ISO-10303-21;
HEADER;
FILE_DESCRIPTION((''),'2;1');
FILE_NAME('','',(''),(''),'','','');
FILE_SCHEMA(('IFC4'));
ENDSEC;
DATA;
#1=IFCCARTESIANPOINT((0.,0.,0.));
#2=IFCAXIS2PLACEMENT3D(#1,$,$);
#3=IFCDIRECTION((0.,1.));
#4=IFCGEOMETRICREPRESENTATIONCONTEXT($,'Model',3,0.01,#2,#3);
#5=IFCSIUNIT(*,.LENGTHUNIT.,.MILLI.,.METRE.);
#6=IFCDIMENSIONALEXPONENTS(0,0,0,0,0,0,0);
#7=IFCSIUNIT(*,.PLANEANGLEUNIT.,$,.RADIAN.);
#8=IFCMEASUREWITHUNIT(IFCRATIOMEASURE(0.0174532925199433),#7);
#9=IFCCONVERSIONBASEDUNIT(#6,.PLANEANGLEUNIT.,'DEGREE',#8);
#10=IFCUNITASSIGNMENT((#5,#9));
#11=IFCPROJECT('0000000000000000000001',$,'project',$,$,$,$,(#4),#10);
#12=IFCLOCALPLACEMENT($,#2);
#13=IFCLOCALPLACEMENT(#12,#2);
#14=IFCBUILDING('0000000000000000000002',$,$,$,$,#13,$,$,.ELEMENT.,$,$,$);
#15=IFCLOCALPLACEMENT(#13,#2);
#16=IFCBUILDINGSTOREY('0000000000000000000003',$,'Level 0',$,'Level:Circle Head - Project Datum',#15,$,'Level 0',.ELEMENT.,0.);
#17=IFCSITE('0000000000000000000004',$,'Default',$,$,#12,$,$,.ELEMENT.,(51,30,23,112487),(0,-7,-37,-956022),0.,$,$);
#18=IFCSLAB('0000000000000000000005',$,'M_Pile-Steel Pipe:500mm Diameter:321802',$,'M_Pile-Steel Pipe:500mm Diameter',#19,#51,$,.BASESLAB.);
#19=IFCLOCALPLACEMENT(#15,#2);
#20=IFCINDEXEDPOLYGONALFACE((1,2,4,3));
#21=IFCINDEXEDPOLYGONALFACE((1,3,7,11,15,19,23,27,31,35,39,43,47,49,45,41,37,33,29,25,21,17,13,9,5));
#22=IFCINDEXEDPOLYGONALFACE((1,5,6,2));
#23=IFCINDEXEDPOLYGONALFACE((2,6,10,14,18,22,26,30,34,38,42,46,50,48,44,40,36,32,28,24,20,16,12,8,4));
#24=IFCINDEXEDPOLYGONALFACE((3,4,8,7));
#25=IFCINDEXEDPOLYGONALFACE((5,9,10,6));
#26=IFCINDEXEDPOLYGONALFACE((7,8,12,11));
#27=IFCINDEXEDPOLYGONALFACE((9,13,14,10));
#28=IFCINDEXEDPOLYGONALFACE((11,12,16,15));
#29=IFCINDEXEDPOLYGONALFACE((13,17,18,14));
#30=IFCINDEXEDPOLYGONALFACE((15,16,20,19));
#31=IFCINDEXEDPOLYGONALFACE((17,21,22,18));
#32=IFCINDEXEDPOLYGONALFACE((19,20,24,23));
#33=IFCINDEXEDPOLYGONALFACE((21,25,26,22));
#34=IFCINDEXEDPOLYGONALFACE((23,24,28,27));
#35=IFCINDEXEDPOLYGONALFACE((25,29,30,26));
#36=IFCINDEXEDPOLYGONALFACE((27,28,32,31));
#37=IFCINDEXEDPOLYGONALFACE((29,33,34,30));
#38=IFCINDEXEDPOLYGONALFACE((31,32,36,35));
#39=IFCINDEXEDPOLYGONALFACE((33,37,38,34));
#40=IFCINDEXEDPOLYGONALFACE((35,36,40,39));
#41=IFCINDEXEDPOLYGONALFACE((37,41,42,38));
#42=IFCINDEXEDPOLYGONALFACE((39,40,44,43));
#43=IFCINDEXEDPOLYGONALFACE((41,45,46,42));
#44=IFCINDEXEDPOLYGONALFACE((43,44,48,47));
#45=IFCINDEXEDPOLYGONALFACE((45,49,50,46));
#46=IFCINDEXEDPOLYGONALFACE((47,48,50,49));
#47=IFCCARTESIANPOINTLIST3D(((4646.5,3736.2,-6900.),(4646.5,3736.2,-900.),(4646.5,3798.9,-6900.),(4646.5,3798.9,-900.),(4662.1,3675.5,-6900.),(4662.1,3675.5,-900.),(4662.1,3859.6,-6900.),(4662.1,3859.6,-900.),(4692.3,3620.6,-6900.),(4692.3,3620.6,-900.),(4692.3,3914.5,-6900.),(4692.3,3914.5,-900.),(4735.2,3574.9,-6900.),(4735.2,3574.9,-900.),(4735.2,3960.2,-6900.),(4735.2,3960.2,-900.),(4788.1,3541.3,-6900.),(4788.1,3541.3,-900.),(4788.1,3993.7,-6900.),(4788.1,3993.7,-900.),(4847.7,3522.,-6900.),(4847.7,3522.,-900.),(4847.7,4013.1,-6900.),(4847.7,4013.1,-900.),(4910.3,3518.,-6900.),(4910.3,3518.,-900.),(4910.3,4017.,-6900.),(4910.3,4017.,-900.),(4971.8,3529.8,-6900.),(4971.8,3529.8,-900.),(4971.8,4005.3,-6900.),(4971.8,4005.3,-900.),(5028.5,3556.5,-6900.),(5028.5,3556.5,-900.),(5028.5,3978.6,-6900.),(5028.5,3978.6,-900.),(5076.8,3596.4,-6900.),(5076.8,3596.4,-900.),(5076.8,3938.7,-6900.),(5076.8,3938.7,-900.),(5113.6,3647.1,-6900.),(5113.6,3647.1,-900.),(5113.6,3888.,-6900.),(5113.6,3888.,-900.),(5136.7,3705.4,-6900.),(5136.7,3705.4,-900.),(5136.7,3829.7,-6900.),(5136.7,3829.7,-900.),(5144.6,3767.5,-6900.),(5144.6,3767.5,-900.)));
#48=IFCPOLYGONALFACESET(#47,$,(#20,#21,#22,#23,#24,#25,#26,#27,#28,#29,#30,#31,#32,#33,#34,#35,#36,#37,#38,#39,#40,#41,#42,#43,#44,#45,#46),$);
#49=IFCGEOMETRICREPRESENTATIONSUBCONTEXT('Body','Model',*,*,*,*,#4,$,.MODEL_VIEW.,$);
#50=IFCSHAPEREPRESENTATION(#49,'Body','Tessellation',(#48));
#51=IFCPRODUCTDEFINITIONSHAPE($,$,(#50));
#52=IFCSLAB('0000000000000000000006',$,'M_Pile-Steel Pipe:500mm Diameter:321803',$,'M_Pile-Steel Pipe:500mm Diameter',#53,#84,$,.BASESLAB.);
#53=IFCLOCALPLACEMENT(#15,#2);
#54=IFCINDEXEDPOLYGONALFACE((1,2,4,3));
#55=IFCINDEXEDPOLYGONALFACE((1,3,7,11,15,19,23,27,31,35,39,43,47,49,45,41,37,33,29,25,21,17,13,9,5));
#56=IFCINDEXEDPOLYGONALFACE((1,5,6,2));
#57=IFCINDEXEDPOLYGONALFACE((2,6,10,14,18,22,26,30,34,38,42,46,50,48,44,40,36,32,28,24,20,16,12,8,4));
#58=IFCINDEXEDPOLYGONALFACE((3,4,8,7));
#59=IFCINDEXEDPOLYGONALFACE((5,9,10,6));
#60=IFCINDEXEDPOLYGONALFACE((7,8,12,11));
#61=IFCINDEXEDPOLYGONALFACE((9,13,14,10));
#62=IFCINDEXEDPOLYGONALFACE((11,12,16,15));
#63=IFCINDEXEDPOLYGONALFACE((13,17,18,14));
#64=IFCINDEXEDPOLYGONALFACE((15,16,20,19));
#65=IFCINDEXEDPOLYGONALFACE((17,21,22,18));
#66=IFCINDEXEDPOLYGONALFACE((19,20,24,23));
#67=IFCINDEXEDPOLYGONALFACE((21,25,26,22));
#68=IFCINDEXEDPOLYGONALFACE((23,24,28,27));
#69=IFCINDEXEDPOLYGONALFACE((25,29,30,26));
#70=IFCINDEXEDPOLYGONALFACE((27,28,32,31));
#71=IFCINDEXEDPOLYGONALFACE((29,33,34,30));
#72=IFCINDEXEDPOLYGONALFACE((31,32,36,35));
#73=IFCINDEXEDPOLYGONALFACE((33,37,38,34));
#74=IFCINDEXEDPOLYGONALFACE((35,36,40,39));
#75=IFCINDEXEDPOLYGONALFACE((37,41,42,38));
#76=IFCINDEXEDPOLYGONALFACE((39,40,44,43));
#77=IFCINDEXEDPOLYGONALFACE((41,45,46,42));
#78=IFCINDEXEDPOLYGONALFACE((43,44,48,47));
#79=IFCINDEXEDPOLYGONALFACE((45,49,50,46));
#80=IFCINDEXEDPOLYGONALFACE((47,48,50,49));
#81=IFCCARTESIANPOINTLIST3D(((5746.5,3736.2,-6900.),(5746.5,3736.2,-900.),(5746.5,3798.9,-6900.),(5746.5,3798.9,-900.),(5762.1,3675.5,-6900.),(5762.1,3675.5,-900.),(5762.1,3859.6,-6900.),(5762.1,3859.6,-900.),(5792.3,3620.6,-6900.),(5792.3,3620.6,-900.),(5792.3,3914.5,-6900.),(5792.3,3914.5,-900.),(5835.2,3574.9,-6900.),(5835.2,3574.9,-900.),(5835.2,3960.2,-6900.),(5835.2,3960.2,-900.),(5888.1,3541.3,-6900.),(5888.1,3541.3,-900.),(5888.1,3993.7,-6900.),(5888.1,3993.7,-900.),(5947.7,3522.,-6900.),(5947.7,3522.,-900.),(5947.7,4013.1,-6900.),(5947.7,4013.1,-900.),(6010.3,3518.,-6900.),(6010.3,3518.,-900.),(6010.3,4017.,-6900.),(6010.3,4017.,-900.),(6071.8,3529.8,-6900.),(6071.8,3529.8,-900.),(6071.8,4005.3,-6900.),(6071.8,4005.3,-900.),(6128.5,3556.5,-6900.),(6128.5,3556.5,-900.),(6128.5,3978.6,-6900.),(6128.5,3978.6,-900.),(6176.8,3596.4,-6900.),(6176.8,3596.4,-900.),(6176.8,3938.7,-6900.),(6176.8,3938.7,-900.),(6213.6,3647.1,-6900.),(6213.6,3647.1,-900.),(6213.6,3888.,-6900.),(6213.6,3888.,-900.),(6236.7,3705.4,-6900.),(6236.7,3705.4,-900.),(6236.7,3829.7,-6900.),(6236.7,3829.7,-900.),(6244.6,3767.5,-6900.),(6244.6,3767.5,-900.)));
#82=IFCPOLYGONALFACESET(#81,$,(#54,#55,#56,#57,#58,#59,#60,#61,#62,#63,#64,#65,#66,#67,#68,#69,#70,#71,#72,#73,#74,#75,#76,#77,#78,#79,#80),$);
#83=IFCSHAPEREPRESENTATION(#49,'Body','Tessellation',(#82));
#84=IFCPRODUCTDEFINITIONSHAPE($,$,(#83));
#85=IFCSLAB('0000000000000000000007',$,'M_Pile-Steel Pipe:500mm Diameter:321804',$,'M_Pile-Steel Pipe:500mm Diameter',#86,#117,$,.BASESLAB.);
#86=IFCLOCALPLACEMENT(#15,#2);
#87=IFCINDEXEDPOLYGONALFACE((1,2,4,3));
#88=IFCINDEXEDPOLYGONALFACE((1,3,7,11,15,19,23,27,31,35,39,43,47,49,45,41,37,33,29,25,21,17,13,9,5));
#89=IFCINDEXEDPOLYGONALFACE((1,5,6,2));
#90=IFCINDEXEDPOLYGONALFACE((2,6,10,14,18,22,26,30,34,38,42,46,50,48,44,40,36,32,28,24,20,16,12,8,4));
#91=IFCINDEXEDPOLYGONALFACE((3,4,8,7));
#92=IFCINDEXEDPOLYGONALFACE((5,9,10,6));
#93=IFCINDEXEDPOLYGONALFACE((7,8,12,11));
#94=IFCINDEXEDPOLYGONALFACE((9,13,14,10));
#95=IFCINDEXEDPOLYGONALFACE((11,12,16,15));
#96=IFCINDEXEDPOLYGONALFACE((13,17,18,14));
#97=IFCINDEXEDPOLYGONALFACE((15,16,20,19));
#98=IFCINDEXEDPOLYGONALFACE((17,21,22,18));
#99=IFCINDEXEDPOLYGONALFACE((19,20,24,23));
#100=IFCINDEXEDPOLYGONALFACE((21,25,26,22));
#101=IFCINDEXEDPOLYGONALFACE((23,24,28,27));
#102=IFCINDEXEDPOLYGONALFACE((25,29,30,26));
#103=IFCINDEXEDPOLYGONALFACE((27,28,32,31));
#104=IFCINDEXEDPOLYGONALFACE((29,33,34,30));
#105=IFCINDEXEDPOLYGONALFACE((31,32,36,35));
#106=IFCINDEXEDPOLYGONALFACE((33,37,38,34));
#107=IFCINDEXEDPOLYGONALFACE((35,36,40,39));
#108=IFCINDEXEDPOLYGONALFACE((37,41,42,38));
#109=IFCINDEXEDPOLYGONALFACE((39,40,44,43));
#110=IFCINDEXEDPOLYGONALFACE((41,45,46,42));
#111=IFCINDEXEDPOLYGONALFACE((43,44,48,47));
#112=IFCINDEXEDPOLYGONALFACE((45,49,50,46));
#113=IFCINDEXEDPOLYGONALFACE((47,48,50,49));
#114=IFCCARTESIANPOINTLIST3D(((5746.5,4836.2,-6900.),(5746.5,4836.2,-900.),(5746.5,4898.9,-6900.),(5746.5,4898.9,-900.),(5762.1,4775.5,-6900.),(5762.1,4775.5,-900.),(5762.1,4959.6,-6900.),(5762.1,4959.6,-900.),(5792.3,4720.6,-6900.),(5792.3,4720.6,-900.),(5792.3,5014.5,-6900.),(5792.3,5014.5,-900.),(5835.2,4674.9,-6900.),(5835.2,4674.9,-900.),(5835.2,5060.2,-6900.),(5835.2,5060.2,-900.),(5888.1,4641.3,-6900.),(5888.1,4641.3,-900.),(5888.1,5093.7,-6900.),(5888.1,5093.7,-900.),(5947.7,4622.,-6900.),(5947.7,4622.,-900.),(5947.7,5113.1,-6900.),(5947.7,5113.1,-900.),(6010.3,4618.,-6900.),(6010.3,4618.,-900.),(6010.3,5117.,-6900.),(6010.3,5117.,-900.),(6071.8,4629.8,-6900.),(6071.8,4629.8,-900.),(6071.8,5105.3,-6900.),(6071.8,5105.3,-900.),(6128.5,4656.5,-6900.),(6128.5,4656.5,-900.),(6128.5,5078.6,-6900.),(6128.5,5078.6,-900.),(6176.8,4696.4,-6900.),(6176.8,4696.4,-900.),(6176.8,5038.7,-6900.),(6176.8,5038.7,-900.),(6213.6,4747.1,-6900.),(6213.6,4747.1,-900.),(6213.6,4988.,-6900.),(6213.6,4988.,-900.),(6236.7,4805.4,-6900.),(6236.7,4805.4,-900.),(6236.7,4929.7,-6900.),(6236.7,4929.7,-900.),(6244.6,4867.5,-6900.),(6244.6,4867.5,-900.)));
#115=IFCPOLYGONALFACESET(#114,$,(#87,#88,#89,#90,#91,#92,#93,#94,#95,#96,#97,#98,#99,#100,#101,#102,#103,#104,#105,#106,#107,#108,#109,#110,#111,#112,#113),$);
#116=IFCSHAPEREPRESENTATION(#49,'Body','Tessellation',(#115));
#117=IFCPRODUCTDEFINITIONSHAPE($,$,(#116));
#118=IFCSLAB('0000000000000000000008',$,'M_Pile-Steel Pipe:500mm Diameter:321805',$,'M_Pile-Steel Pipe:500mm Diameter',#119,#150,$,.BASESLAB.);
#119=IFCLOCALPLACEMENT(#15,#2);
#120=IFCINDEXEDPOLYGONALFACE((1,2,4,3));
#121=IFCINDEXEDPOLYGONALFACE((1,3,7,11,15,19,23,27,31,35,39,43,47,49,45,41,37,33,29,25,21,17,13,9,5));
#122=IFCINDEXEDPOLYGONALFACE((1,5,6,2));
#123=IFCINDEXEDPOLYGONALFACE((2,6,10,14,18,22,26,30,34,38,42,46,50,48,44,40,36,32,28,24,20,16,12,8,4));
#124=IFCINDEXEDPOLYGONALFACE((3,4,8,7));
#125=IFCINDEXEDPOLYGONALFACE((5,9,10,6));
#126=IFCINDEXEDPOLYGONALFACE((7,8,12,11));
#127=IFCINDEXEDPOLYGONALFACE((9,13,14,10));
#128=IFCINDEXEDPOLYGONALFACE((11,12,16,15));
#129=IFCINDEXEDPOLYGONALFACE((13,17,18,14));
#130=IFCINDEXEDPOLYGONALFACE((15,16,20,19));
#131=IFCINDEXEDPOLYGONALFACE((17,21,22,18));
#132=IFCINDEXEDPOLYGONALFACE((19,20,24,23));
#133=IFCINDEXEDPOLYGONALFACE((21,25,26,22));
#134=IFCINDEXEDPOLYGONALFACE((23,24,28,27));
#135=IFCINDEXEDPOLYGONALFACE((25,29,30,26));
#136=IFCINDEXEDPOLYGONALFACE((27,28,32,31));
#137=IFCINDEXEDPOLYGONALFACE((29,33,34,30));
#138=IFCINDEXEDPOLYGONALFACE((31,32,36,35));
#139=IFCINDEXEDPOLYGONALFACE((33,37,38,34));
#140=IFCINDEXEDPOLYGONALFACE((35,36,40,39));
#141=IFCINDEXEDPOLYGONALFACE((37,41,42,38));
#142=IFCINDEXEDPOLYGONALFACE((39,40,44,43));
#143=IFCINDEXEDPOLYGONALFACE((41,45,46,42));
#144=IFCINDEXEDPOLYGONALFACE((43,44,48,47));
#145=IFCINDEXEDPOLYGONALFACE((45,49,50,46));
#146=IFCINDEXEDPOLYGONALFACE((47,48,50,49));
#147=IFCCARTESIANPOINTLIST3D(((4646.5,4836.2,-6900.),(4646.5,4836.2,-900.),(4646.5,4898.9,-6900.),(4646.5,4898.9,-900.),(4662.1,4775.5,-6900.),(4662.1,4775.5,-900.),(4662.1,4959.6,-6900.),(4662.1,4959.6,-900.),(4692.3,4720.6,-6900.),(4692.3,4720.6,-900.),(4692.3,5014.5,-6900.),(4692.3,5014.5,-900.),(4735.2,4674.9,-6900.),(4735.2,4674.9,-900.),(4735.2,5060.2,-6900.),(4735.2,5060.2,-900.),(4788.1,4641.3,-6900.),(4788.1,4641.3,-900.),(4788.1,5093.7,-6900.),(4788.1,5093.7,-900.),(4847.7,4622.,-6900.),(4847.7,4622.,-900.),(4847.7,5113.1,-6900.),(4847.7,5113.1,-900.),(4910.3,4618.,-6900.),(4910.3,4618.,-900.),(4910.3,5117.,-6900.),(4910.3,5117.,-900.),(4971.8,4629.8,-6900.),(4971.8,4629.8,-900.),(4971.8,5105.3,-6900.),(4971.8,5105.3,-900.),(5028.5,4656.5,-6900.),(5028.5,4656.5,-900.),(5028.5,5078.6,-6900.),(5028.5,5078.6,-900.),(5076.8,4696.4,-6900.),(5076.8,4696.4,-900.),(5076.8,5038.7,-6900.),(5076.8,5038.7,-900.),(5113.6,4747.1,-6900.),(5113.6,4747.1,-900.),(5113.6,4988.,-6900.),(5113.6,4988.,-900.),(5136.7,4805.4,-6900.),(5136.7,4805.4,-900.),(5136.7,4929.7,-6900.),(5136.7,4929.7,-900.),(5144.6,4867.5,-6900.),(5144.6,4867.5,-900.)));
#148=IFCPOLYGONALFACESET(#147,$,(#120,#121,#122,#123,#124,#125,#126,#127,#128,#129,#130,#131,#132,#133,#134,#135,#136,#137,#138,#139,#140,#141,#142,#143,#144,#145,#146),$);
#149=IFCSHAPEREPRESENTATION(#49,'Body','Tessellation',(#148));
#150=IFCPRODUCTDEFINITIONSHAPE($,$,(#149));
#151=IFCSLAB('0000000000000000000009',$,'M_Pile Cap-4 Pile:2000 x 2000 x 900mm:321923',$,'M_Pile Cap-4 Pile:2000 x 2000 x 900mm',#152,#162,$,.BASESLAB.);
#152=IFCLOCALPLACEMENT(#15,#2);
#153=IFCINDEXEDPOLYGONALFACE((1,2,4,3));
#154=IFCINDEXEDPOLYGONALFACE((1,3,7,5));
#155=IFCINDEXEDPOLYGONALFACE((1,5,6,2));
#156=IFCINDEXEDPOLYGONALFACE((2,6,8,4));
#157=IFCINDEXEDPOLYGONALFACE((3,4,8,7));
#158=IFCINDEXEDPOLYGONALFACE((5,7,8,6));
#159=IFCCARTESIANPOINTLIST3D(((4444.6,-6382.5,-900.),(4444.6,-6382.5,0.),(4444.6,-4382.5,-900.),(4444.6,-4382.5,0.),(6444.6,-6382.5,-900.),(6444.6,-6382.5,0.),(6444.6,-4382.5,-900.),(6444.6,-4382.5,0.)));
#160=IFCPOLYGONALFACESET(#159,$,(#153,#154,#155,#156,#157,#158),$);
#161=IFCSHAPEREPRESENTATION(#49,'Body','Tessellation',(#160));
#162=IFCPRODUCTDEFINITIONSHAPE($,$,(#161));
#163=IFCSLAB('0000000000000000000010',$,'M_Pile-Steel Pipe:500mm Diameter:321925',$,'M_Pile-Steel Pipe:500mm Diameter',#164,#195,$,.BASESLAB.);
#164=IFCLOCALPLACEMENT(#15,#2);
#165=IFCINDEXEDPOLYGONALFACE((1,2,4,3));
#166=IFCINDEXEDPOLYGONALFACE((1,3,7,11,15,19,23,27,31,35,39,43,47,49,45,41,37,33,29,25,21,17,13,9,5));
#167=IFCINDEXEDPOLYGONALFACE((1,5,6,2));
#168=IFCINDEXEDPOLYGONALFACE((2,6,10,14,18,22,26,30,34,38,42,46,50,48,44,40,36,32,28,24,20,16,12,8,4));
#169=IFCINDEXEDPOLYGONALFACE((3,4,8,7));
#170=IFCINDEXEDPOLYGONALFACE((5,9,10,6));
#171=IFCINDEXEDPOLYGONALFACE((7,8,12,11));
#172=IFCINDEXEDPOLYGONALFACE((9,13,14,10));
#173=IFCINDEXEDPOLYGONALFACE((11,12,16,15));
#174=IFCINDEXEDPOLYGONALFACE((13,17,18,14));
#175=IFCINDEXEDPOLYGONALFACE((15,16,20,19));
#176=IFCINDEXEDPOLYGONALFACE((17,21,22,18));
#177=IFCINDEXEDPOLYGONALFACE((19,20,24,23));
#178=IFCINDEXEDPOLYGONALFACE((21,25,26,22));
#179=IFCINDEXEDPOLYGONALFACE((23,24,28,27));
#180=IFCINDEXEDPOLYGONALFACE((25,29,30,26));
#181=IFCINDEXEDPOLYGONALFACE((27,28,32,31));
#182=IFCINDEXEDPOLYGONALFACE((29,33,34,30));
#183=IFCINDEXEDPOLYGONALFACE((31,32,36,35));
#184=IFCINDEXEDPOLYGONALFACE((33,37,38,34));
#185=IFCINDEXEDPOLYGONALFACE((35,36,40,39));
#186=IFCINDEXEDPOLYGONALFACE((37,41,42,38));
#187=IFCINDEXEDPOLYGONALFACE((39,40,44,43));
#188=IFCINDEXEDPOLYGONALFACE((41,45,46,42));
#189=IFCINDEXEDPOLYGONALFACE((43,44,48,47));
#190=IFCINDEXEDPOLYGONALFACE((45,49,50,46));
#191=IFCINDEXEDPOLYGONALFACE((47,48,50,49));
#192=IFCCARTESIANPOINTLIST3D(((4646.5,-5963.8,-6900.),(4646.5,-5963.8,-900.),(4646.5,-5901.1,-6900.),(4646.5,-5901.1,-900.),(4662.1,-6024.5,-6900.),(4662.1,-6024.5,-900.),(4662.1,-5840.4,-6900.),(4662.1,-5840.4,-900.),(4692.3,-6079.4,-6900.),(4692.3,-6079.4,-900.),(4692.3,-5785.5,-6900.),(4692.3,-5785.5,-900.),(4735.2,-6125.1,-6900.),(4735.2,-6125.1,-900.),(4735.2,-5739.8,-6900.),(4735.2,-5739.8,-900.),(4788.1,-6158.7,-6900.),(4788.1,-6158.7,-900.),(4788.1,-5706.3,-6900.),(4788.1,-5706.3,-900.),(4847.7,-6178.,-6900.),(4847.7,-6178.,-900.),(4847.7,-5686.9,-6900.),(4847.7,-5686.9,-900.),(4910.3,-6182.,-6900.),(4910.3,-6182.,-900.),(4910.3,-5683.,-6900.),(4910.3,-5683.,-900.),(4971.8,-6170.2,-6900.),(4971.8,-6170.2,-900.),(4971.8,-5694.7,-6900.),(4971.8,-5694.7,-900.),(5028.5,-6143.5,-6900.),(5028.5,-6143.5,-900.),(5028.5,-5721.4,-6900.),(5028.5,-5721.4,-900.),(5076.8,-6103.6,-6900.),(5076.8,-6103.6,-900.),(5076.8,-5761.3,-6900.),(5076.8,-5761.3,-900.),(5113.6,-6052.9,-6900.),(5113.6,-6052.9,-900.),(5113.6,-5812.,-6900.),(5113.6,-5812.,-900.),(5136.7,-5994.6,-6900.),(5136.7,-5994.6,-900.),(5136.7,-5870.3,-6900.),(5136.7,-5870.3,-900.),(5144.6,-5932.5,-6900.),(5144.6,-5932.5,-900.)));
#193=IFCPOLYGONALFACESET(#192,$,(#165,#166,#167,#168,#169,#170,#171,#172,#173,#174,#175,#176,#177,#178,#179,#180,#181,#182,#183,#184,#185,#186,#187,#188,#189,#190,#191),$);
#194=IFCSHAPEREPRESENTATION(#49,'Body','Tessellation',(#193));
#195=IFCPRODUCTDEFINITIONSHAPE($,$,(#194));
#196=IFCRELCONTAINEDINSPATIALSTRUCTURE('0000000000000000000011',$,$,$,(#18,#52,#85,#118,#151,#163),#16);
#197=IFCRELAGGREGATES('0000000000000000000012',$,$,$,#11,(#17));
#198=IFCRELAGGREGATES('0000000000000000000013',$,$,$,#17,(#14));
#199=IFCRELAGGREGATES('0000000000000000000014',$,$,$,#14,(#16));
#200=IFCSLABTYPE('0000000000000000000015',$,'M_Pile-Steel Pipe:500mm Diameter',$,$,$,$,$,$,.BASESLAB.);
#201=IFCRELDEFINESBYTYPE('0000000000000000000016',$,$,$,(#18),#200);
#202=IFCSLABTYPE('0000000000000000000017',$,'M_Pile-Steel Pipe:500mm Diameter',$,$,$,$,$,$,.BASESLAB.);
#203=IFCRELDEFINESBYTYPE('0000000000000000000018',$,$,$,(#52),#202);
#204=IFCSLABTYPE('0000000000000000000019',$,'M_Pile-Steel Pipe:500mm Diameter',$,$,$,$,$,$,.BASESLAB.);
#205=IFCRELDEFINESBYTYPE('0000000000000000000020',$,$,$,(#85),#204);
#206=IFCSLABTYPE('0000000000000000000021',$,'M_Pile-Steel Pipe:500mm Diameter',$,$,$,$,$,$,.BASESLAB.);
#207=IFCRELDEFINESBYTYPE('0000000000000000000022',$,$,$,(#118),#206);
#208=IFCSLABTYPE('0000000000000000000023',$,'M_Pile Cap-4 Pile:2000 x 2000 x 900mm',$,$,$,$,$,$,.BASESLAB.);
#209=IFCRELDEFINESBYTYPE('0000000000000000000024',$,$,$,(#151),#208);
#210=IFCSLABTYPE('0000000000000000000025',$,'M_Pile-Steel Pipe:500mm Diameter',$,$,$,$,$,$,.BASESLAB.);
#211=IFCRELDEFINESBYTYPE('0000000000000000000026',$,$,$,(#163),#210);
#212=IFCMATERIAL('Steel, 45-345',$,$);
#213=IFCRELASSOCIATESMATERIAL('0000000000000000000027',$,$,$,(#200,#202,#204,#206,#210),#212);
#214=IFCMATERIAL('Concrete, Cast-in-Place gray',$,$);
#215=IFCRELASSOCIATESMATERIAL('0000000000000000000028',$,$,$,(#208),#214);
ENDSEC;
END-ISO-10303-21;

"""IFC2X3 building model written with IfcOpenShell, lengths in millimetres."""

from ifc_helpers import new_model, entity, si_unit, converted_unit, direction, frame, frame_2d, origin, origin_2d_with_axis, place, context, subcontext, project, spatial, rectangle, circle, extrude, material, type_object, element, save


model = new_model("IFC2X3")

# Units and contexts
model_context = context("Model", 3, precision=0.01, world=origin(), true_north=direction((0.0, 1.0)))
body_context = subcontext(model_context, "Body", "Model", "MODEL_VIEW")
ifc_project = project(units=[si_unit("LENGTHUNIT", "METRE", prefix="MILLI"), converted_unit("PLANEANGLEUNIT", "DEGREE", entity("IfcRatioMeasure", 0.0174532925199433), si_unit("PLANEANGLEUNIT", "RADIAN"), dimensions=[0, 0, 0, 0, 0, 0, 0])], contexts=[model_context])

# Site, building, storey
site_placement = place(None, origin())
site = spatial("IfcSite", under=ifc_project, at=site_placement, Name="Default", CompositionType="ELEMENT", RefLatitude=(51, 30, 23, 112487), RefLongitude=(0, -7, -37, -956022), RefElevation=0.0)
building_placement = place(site_placement, origin())
building = spatial("IfcBuilding", under=site, at=building_placement, CompositionType="ELEMENT")
storey_placement = place(building_placement, origin())
storey = spatial("IfcBuildingStorey", under=building, at=storey_placement, Name="Level 0", ObjectType="Level:Circle Head - Project Datum", LongName="Level 0", CompositionType="ELEMENT", Elevation=0.0)

# Slabs
ifc_material_1 = material(Name="Concrete, Cast-in-Place gray")
ifc_material_2 = material(Name="Steel, 45-345")
slab_type_1 = type_object("IfcSlabType", Name="M_Pile-Steel Pipe:500mm Diameter", PredefinedType="BASESLAB", material=ifc_material_2)
slab_1_placement = place(storey_placement, origin())
element("IfcSlab", 1, at=slab_1_placement, inside=storey, type_object=slab_type_1, Name="M_Pile-Steel Pipe:500mm Diameter:321802", ObjectType="M_Pile-Steel Pipe:500mm Diameter", PredefinedType="BASESLAB", context=body_context, shape_type="SweptSolid", body=[
    extrude(circle(Radius=250.0, at=origin_2d_with_axis()), frame((4894.6, 3767.5, -6900.0)), (0.0, 0.0, 1.0), 6000.0),
])
slab_type_2 = type_object("IfcSlabType", Name="M_Pile-Steel Pipe:500mm Diameter", PredefinedType="BASESLAB", material=ifc_material_2)
slab_2_placement = place(storey_placement, origin())
element("IfcSlab", 2, at=slab_2_placement, inside=storey, type_object=slab_type_2, Name="M_Pile-Steel Pipe:500mm Diameter:321803", ObjectType="M_Pile-Steel Pipe:500mm Diameter", PredefinedType="BASESLAB", context=body_context, shape_type="SweptSolid", body=[
    extrude(circle(Radius=250.0, at=frame_2d((0.0, 0.0), x_axis=(1.0, 0.0))), frame((5994.6, 3767.5, -6900.0)), (0.0, 0.0, 1.0), 6000.0),
])
slab_type_3 = type_object("IfcSlabType", Name="M_Pile-Steel Pipe:500mm Diameter", PredefinedType="BASESLAB", material=ifc_material_2)
slab_3_placement = place(storey_placement, origin())
element("IfcSlab", 3, at=slab_3_placement, inside=storey, type_object=slab_type_3, Name="M_Pile-Steel Pipe:500mm Diameter:321804", ObjectType="M_Pile-Steel Pipe:500mm Diameter", PredefinedType="BASESLAB", context=body_context, shape_type="SweptSolid", body=[
    extrude(circle(Radius=250.0, at=frame_2d((0.0, 0.0), x_axis=(1.0, 0.0))), frame((5994.6, 4867.5, -6900.0)), (0.0, 0.0, 1.0), 6000.0),
])
slab_type_4 = type_object("IfcSlabType", Name="M_Pile-Steel Pipe:500mm Diameter", PredefinedType="BASESLAB", material=ifc_material_2)
slab_4_placement = place(storey_placement, origin())
element("IfcSlab", 4, at=slab_4_placement, inside=storey, type_object=slab_type_4, Name="M_Pile-Steel Pipe:500mm Diameter:321805", ObjectType="M_Pile-Steel Pipe:500mm Diameter", PredefinedType="BASESLAB", context=body_context, shape_type="SweptSolid", body=[
    extrude(circle(Radius=250.0, at=frame_2d((0.0, 0.0), x_axis=(1.0, 0.0))), frame((4894.6, 4867.5, -6900.0)), (0.0, 0.0, 1.0), 6000.0),
])
slab_type_5 = type_object("IfcSlabType", Name="M_Pile Cap-4 Pile:2000 x 2000 x 900mm", PredefinedType="BASESLAB", material=ifc_material_1)
slab_5_placement = place(storey_placement, origin())
element("IfcSlab", 5, at=slab_5_placement, inside=storey, type_object=slab_type_5, Name="M_Pile Cap-4 Pile:2000 x 2000 x 900mm:321923", ObjectType="M_Pile Cap-4 Pile:2000 x 2000 x 900mm", PredefinedType="BASESLAB", context=body_context, shape_type="SweptSolid", body=[
    extrude(rectangle(XDim=2000.0, YDim=2000.0, at=frame_2d((0.0, 0.0), x_axis=(1.0, 0.0))), frame((5444.6, -5382.5, -900.0), z_axis=(0.0, 0.0, 1.0), x_axis=(-1.0, 0.0, 0.0)), (0.0, 0.0, 1.0), 900.0),
])
slab_type_6 = type_object("IfcSlabType", Name="M_Pile-Steel Pipe:500mm Diameter", PredefinedType="BASESLAB", material=ifc_material_2)
slab_6_placement = place(storey_placement, origin())
element("IfcSlab", 6, at=slab_6_placement, inside=storey, type_object=slab_type_6, Name="M_Pile-Steel Pipe:500mm Diameter:321925", ObjectType="M_Pile-Steel Pipe:500mm Diameter", PredefinedType="BASESLAB", context=body_context, shape_type="SweptSolid", body=[
    extrude(circle(Radius=250.0, at=origin_2d_with_axis()), frame((4894.6, -5932.5, -6900.0)), (0.0, 0.0, 1.0), 6000.0),
])

save(model, "model.ifc")
